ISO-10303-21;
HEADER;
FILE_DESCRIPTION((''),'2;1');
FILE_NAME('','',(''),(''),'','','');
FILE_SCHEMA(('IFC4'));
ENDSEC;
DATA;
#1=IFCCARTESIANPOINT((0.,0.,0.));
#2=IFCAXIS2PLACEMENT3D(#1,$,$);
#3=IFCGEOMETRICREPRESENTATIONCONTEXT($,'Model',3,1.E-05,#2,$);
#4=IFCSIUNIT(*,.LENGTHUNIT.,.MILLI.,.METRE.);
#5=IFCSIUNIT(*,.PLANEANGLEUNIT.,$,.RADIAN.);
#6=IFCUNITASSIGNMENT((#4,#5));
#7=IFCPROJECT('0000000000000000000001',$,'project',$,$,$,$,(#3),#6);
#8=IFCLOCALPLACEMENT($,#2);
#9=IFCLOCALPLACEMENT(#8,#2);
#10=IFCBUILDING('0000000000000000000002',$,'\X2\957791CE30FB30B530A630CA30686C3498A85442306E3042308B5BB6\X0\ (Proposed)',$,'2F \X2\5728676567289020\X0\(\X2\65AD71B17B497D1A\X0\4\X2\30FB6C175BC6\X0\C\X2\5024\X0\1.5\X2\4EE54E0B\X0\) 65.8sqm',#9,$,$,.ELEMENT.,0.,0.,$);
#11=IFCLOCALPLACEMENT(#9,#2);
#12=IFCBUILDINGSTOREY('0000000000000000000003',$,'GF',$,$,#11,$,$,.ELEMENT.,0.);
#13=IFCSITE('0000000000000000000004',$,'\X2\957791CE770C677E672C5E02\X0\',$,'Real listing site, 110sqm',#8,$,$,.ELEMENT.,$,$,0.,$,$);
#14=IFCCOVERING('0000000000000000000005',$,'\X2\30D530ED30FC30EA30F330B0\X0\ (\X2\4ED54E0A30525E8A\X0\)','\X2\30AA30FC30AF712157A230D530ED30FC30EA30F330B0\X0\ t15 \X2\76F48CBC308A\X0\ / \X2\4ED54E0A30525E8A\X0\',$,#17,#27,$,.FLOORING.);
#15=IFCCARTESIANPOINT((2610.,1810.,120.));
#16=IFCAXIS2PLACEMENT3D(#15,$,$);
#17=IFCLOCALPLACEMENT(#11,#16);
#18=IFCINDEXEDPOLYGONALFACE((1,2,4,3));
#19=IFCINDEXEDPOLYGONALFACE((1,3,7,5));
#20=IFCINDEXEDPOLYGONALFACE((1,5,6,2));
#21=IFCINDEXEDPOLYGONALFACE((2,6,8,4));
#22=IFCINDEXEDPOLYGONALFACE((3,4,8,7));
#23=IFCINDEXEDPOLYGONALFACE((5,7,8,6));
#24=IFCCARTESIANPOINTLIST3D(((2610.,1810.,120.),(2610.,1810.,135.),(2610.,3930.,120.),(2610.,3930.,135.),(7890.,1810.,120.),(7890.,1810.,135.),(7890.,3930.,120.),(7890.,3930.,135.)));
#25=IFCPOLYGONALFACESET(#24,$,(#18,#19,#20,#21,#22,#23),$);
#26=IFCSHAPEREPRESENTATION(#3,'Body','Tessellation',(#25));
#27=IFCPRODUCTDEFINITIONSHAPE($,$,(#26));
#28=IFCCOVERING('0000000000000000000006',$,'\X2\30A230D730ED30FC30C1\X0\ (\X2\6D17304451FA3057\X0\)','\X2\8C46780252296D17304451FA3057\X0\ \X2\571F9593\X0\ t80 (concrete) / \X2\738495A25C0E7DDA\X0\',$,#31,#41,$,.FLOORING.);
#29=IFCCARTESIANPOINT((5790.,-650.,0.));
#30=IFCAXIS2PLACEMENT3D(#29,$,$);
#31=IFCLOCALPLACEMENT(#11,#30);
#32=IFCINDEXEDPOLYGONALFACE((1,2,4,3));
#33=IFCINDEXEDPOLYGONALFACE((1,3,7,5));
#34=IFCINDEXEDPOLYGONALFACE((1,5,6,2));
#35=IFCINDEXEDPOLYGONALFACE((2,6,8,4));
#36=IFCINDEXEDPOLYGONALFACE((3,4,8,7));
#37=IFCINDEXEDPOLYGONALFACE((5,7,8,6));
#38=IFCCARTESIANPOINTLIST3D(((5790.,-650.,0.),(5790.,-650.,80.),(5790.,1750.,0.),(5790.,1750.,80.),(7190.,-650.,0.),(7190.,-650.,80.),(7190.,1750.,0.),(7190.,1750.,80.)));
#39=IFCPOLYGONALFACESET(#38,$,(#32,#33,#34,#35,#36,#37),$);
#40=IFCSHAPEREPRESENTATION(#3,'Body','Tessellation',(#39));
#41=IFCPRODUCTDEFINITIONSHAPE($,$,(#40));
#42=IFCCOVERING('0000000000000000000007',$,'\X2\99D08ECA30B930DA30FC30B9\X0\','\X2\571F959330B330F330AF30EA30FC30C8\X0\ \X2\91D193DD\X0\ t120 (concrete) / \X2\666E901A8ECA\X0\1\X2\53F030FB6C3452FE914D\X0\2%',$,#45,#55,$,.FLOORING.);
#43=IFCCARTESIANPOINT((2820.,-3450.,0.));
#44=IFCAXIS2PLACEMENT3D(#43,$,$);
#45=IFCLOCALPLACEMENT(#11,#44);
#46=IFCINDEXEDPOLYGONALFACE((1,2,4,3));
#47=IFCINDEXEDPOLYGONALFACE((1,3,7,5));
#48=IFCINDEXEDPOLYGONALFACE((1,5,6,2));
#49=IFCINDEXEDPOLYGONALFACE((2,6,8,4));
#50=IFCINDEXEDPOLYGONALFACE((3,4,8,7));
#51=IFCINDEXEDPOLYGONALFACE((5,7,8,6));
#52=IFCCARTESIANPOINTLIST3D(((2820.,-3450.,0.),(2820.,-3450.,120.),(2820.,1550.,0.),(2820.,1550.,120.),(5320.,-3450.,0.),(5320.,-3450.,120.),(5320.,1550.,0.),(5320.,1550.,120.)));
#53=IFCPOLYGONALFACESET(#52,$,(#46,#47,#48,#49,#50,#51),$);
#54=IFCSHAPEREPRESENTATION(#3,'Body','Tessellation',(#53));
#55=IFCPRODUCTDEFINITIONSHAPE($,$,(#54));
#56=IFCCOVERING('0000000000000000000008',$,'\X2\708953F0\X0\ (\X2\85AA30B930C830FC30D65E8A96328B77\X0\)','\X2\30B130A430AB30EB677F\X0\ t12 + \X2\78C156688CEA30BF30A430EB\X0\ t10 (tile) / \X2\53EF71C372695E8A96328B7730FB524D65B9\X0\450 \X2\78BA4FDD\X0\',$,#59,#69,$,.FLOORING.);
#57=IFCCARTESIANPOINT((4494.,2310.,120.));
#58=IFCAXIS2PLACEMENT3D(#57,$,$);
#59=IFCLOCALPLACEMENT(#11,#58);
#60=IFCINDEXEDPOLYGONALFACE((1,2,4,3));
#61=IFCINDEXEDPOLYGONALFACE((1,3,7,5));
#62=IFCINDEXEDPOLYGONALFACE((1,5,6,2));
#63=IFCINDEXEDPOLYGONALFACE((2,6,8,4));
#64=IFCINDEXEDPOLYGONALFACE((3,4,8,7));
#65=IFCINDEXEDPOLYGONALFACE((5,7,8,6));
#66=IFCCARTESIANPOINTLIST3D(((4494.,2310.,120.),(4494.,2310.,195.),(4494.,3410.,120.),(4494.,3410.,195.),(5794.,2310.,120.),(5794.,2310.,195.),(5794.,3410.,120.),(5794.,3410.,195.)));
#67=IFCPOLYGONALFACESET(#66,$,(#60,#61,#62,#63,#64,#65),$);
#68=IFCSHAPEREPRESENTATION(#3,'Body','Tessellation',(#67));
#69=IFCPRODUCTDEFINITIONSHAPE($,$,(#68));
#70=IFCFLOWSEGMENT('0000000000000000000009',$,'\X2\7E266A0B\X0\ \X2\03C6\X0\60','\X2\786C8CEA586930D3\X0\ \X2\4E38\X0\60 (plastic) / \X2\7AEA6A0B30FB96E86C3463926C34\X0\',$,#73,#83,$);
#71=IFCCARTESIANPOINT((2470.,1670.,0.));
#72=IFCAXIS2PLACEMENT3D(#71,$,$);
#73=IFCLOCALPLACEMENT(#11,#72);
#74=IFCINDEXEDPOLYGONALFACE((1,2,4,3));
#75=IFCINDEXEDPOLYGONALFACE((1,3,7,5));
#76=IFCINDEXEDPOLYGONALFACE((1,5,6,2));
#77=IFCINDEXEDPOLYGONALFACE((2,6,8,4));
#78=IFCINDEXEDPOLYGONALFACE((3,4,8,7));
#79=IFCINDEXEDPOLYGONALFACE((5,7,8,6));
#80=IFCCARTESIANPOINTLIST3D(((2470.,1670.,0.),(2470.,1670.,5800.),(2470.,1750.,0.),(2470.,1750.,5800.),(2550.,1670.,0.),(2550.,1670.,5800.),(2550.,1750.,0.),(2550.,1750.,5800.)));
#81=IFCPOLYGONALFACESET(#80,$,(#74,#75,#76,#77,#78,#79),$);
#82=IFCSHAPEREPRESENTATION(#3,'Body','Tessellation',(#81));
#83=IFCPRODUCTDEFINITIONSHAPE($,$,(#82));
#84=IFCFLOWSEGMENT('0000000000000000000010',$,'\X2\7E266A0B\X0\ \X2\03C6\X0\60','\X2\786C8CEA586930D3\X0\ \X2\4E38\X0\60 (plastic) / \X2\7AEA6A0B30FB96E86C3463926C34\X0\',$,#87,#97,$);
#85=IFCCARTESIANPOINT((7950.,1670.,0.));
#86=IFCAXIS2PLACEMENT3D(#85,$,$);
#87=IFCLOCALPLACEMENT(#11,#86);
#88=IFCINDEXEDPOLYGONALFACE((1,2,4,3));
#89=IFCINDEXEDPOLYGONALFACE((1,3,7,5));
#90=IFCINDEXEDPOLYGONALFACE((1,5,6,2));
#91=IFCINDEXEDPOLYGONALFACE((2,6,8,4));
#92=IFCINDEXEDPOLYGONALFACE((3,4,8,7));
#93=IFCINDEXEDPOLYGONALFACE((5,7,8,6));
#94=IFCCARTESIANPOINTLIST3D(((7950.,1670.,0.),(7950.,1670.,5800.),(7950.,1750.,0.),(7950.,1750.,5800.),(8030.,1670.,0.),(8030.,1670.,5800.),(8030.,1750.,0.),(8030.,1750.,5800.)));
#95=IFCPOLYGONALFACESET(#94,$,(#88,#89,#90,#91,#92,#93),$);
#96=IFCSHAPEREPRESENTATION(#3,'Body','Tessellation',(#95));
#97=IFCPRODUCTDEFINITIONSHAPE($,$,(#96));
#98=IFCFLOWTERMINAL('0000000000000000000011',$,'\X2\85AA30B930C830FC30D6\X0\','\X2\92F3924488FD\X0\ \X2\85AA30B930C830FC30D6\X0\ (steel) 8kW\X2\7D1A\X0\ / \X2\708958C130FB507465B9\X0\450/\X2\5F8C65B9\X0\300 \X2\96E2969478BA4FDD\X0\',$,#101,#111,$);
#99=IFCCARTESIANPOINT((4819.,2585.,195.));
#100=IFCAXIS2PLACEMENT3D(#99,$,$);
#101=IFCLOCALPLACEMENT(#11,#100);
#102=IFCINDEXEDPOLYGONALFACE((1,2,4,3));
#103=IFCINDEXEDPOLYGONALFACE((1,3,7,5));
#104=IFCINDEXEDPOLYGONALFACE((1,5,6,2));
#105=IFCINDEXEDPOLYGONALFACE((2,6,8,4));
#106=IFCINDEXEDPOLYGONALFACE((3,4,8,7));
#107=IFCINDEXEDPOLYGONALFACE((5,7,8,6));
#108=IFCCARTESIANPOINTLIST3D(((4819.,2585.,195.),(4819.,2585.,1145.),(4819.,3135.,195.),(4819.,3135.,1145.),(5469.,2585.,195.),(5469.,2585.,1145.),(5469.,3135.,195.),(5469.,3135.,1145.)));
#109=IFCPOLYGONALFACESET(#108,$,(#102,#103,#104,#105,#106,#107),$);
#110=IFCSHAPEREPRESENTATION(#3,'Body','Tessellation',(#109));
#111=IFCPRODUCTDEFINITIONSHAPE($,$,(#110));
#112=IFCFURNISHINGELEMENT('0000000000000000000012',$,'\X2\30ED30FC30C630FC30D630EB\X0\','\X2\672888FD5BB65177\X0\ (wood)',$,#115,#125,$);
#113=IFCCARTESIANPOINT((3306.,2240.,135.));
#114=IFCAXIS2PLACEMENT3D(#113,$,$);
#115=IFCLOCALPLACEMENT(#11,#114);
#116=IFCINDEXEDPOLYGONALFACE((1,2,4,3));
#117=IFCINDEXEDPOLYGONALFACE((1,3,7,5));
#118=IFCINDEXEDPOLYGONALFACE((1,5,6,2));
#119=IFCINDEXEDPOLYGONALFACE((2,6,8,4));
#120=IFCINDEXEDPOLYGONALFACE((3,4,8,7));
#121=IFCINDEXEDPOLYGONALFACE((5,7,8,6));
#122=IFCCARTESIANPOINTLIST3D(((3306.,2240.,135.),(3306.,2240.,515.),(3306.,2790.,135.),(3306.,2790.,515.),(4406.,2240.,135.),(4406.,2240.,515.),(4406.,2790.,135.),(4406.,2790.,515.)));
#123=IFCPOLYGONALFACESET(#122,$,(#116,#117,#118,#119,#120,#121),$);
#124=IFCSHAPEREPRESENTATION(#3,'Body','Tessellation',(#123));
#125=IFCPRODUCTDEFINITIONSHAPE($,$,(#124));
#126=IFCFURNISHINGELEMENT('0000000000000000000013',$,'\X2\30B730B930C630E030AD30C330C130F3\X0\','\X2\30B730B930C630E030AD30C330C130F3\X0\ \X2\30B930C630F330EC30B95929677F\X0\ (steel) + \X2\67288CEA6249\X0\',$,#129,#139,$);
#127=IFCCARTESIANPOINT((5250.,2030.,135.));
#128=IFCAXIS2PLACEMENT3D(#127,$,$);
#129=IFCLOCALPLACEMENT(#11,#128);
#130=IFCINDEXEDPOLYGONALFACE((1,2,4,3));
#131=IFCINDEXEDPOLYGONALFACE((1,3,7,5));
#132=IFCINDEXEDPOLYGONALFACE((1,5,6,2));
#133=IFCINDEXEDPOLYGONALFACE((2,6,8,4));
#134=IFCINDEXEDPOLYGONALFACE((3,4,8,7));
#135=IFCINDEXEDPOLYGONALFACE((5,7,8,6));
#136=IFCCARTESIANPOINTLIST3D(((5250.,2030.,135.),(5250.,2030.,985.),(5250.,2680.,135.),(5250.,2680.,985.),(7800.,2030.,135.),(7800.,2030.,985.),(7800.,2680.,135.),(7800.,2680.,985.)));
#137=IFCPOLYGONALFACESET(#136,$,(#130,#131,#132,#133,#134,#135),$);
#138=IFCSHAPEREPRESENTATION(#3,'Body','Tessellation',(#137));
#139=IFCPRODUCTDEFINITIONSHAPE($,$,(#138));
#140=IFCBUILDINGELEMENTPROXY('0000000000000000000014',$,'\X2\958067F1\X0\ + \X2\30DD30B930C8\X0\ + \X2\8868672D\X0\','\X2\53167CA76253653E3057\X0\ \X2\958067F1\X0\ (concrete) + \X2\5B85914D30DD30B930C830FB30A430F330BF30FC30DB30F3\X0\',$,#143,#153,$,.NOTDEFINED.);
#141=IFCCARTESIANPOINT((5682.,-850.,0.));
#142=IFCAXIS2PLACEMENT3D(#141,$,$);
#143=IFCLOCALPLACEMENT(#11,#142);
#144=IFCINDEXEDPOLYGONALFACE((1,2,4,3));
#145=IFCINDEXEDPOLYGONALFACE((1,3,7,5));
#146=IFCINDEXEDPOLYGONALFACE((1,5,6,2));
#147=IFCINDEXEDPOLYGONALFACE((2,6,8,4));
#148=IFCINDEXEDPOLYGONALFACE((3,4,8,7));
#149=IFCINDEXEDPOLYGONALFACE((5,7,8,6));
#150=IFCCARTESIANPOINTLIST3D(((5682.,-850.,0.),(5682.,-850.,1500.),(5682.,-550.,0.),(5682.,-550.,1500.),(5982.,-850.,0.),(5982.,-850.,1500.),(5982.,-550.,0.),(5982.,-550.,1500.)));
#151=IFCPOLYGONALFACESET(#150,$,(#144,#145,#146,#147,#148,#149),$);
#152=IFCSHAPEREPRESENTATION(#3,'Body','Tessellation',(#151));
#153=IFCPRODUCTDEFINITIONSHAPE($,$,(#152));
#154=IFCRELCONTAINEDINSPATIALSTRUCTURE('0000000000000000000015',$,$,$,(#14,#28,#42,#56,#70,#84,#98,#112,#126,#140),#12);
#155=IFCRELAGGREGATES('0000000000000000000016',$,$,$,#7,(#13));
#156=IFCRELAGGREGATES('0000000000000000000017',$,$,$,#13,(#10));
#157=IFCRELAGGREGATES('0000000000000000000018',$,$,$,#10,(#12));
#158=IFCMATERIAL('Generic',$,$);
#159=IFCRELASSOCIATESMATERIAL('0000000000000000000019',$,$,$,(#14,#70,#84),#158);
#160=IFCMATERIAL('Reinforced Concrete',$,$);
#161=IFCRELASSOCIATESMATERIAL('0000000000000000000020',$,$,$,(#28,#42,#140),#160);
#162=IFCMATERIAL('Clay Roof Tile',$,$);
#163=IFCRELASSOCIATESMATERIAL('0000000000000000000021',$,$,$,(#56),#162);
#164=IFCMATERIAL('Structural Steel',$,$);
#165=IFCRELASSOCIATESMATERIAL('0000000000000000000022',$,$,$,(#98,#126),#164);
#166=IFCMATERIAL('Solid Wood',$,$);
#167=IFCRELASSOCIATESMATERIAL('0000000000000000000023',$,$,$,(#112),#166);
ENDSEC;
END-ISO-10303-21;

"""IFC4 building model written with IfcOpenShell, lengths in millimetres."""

from ifc_helpers import new_model, si_unit, frame, frame_2d, origin, place, context, project, spatial, rectangle, extrude, material, element, save


model = new_model("IFC4")

# Units and contexts
model_context = context("Model", 3, precision=1e-05, world=origin())
ifc_project = project(units=[si_unit("LENGTHUNIT", "METRE", prefix="MILLI"), si_unit("PLANEANGLEUNIT", "RADIAN")], contexts=[model_context])

# Site, building, storey
site_placement = place(None, origin())
site = spatial("IfcSite", under=ifc_project, at=site_placement, Name="長野県松本市", ObjectType="Real listing site, 110sqm", CompositionType="ELEMENT", RefElevation=0.0)
building_placement = place(site_placement, origin())
building = spatial("IfcBuilding", under=site, at=building_placement, Name="長野・サウナと水風呂のある家 (Proposed)", ObjectType="2F 在来木造(断熱等級4・気密C値1.5以下) 65.8sqm", CompositionType="ELEMENT", ElevationOfRefHeight=0.0, ElevationOfTerrain=0.0)
storey_placement = place(building_placement, origin())
storey = spatial("IfcBuildingStorey", under=building, at=storey_placement, Name="GF", CompositionType="ELEMENT", Elevation=0.0)

# Shared definitions
ifc_material_1 = material(Name="Solid Wood")

# Shared definitions
ifc_material_2 = material(Name="Reinforced Concrete")

# Coverings
ifc_material_3 = material(Name="Generic")
covering_1_placement = place(storey_placement, frame((2610.0, 1810.0, 120.0)))
element("IfcCovering", 1, at=covering_1_placement, inside=storey, material=ifc_material_3, Name="フローリング (仕上げ床)", Description="オーク無垢フローリング t15 直貼り / 仕上げ床", PredefinedType="FLOORING", context=model_context, shape_type="SweptSolid", body=[
    extrude(rectangle(XDim=5280.0, YDim=2120.0, at=frame_2d((2640.0, 1060.0))), frame((2610.0, 1810.0, 120.0)), (0.0, 0.0, 1.0), 15.0),
])
covering_2_placement = place(storey_placement, frame((5790.0, -650.0, 0.0)))
element("IfcCovering", 2, at=covering_2_placement, inside=storey, material=ifc_material_2, Name="アプローチ (洗い出し)", Description="豆砂利洗い出し 土間 t80 (concrete) / 玄関導線", PredefinedType="FLOORING", context=model_context, shape_type="SweptSolid", body=[
    extrude(rectangle(XDim=1400.0, YDim=2400.0, at=frame_2d((700.0, 1200.0))), frame((5790.0, -650.0, 0.0)), (0.0, 0.0, 1.0), 80.0),
])
covering_3_placement = place(storey_placement, frame((2820.0, -3450.0, 0.0)))
element("IfcCovering", 3, at=covering_3_placement, inside=storey, material=ifc_material_2, Name="駐車スペース", Description="土間コンクリート 金鏝 t120 (concrete) / 普通車1台・水勾配2%", PredefinedType="FLOORING", context=model_context, shape_type="SweptSolid", body=[
    extrude(rectangle(XDim=2500.0, YDim=5000.0, at=frame_2d((1250.0, 2500.0))), frame((2820.0, -3450.0, 0.0)), (0.0, 0.0, 1.0), 120.0),
])
ifc_material_4 = material(Name="Clay Roof Tile")
covering_4_placement = place(storey_placement, frame((4494.0, 2310.0, 120.0)))
element("IfcCovering", 4, at=covering_4_placement, inside=storey, material=ifc_material_4, Name="炉台 (薪ストーブ床防護)", Description="ケイカル板 t12 + 磁器質タイル t10 (tile) / 可燃物床防護・前方450 確保", PredefinedType="FLOORING", context=model_context, shape_type="SweptSolid", body=[
    extrude(rectangle(XDim=1300.0, YDim=1100.0, at=frame_2d((650.0, 550.0))), frame((4494.0, 2310.0, 120.0)), (0.0, 0.0, 1.0), 75.0),
])

# Flow segments
flow_segment_1_placement = place(storey_placement, frame((2470.0, 1670.0, 0.0)))
element("IfcFlowSegment", 5, at=flow_segment_1_placement, inside=storey, material=ifc_material_3, Name="縦樋 φ60", Description="硬質塩ビ 丸60 (plastic) / 竪樋・雨水排水", context=model_context, shape_type="SweptSolid", body=[
    extrude(rectangle(XDim=80.0, YDim=80.0, at=frame_2d((40.0, 40.0))), frame((2470.0, 1670.0, 0.0)), (0.0, 0.0, 1.0), 5800.0),
])
flow_segment_2_placement = place(storey_placement, frame((7950.0, 1670.0, 0.0)))
element("IfcFlowSegment", 6, at=flow_segment_2_placement, inside=storey, material=ifc_material_3, Name="縦樋 φ60", Description="硬質塩ビ 丸60 (plastic) / 竪樋・雨水排水", context=model_context, shape_type="SweptSolid", body=[
    extrude(rectangle(XDim=80.0, YDim=80.0, at=frame_2d((40.0, 40.0))), frame((7950.0, 1670.0, 0.0)), (0.0, 0.0, 1.0), 5800.0),
])

# Flow terminal
ifc_material_5 = material(Name="Structural Steel")
flow_terminal_placement = place(storey_placement, frame((4819.0, 2585.0, 195.0)))
element("IfcFlowTerminal", 7, at=flow_terminal_placement, inside=storey, material=ifc_material_5, Name="薪ストーブ", Description="鋳鉄製 薪ストーブ (steel) 8kW級 / 炉壁・側方450/後方300 離隔確保", context=model_context, shape_type="SweptSolid", body=[
    extrude(rectangle(XDim=650.0, YDim=550.0, at=frame_2d((325.0, 275.0))), frame((4819.0, 2585.0, 195.0)), (0.0, 0.0, 1.0), 950.0),
])

# Furnishing elements
furnishing_1_placement = place(storey_placement, frame((3306.0, 2240.0, 135.0)))
element("IfcFurnishingElement", 8, at=furnishing_1_placement, inside=storey, material=ifc_material_1, Name="ローテーブル", Description="木製家具 (wood)", context=model_context, shape_type="SweptSolid", body=[
    extrude(rectangle(XDim=1100.0, YDim=550.0, at=frame_2d((550.0, 275.0))), frame((3306.0, 2240.0, 135.0)), (0.0, 0.0, 1.0), 380.0),
])
furnishing_2_placement = place(storey_placement, frame((5250.0, 2030.0, 135.0)))
element("IfcFurnishingElement", 9, at=furnishing_2_placement, inside=storey, material=ifc_material_5, Name="システムキッチン", Description="システムキッチン ステンレス天板 (steel) + 木質扉", context=model_context, shape_type="SweptSolid", body=[
    extrude(rectangle(XDim=2550.0, YDim=650.0, at=frame_2d((1275.0, 325.0))), frame((5250.0, 2030.0, 135.0)), (0.0, 0.0, 1.0), 850.0),
])

# Building element proxy
proxy_placement = place(storey_placement, frame((5682.0, -850.0, 0.0)))
element("IfcBuildingElementProxy", 10, at=proxy_placement, inside=storey, material=ifc_material_2, Name="門柱 + ポスト + 表札", Description="化粧打放し 門柱 (concrete) + 宅配ポスト・インターホン", PredefinedType="NOTDEFINED", context=model_context, shape_type="SweptSolid", body=[
    extrude(rectangle(XDim=300.0, YDim=300.0, at=frame_2d((150.0, 150.0))), frame((5682.0, -850.0, 0.0)), (0.0, 0.0, 1.0), 1500.0),
])

save(model, "model.ifc")
